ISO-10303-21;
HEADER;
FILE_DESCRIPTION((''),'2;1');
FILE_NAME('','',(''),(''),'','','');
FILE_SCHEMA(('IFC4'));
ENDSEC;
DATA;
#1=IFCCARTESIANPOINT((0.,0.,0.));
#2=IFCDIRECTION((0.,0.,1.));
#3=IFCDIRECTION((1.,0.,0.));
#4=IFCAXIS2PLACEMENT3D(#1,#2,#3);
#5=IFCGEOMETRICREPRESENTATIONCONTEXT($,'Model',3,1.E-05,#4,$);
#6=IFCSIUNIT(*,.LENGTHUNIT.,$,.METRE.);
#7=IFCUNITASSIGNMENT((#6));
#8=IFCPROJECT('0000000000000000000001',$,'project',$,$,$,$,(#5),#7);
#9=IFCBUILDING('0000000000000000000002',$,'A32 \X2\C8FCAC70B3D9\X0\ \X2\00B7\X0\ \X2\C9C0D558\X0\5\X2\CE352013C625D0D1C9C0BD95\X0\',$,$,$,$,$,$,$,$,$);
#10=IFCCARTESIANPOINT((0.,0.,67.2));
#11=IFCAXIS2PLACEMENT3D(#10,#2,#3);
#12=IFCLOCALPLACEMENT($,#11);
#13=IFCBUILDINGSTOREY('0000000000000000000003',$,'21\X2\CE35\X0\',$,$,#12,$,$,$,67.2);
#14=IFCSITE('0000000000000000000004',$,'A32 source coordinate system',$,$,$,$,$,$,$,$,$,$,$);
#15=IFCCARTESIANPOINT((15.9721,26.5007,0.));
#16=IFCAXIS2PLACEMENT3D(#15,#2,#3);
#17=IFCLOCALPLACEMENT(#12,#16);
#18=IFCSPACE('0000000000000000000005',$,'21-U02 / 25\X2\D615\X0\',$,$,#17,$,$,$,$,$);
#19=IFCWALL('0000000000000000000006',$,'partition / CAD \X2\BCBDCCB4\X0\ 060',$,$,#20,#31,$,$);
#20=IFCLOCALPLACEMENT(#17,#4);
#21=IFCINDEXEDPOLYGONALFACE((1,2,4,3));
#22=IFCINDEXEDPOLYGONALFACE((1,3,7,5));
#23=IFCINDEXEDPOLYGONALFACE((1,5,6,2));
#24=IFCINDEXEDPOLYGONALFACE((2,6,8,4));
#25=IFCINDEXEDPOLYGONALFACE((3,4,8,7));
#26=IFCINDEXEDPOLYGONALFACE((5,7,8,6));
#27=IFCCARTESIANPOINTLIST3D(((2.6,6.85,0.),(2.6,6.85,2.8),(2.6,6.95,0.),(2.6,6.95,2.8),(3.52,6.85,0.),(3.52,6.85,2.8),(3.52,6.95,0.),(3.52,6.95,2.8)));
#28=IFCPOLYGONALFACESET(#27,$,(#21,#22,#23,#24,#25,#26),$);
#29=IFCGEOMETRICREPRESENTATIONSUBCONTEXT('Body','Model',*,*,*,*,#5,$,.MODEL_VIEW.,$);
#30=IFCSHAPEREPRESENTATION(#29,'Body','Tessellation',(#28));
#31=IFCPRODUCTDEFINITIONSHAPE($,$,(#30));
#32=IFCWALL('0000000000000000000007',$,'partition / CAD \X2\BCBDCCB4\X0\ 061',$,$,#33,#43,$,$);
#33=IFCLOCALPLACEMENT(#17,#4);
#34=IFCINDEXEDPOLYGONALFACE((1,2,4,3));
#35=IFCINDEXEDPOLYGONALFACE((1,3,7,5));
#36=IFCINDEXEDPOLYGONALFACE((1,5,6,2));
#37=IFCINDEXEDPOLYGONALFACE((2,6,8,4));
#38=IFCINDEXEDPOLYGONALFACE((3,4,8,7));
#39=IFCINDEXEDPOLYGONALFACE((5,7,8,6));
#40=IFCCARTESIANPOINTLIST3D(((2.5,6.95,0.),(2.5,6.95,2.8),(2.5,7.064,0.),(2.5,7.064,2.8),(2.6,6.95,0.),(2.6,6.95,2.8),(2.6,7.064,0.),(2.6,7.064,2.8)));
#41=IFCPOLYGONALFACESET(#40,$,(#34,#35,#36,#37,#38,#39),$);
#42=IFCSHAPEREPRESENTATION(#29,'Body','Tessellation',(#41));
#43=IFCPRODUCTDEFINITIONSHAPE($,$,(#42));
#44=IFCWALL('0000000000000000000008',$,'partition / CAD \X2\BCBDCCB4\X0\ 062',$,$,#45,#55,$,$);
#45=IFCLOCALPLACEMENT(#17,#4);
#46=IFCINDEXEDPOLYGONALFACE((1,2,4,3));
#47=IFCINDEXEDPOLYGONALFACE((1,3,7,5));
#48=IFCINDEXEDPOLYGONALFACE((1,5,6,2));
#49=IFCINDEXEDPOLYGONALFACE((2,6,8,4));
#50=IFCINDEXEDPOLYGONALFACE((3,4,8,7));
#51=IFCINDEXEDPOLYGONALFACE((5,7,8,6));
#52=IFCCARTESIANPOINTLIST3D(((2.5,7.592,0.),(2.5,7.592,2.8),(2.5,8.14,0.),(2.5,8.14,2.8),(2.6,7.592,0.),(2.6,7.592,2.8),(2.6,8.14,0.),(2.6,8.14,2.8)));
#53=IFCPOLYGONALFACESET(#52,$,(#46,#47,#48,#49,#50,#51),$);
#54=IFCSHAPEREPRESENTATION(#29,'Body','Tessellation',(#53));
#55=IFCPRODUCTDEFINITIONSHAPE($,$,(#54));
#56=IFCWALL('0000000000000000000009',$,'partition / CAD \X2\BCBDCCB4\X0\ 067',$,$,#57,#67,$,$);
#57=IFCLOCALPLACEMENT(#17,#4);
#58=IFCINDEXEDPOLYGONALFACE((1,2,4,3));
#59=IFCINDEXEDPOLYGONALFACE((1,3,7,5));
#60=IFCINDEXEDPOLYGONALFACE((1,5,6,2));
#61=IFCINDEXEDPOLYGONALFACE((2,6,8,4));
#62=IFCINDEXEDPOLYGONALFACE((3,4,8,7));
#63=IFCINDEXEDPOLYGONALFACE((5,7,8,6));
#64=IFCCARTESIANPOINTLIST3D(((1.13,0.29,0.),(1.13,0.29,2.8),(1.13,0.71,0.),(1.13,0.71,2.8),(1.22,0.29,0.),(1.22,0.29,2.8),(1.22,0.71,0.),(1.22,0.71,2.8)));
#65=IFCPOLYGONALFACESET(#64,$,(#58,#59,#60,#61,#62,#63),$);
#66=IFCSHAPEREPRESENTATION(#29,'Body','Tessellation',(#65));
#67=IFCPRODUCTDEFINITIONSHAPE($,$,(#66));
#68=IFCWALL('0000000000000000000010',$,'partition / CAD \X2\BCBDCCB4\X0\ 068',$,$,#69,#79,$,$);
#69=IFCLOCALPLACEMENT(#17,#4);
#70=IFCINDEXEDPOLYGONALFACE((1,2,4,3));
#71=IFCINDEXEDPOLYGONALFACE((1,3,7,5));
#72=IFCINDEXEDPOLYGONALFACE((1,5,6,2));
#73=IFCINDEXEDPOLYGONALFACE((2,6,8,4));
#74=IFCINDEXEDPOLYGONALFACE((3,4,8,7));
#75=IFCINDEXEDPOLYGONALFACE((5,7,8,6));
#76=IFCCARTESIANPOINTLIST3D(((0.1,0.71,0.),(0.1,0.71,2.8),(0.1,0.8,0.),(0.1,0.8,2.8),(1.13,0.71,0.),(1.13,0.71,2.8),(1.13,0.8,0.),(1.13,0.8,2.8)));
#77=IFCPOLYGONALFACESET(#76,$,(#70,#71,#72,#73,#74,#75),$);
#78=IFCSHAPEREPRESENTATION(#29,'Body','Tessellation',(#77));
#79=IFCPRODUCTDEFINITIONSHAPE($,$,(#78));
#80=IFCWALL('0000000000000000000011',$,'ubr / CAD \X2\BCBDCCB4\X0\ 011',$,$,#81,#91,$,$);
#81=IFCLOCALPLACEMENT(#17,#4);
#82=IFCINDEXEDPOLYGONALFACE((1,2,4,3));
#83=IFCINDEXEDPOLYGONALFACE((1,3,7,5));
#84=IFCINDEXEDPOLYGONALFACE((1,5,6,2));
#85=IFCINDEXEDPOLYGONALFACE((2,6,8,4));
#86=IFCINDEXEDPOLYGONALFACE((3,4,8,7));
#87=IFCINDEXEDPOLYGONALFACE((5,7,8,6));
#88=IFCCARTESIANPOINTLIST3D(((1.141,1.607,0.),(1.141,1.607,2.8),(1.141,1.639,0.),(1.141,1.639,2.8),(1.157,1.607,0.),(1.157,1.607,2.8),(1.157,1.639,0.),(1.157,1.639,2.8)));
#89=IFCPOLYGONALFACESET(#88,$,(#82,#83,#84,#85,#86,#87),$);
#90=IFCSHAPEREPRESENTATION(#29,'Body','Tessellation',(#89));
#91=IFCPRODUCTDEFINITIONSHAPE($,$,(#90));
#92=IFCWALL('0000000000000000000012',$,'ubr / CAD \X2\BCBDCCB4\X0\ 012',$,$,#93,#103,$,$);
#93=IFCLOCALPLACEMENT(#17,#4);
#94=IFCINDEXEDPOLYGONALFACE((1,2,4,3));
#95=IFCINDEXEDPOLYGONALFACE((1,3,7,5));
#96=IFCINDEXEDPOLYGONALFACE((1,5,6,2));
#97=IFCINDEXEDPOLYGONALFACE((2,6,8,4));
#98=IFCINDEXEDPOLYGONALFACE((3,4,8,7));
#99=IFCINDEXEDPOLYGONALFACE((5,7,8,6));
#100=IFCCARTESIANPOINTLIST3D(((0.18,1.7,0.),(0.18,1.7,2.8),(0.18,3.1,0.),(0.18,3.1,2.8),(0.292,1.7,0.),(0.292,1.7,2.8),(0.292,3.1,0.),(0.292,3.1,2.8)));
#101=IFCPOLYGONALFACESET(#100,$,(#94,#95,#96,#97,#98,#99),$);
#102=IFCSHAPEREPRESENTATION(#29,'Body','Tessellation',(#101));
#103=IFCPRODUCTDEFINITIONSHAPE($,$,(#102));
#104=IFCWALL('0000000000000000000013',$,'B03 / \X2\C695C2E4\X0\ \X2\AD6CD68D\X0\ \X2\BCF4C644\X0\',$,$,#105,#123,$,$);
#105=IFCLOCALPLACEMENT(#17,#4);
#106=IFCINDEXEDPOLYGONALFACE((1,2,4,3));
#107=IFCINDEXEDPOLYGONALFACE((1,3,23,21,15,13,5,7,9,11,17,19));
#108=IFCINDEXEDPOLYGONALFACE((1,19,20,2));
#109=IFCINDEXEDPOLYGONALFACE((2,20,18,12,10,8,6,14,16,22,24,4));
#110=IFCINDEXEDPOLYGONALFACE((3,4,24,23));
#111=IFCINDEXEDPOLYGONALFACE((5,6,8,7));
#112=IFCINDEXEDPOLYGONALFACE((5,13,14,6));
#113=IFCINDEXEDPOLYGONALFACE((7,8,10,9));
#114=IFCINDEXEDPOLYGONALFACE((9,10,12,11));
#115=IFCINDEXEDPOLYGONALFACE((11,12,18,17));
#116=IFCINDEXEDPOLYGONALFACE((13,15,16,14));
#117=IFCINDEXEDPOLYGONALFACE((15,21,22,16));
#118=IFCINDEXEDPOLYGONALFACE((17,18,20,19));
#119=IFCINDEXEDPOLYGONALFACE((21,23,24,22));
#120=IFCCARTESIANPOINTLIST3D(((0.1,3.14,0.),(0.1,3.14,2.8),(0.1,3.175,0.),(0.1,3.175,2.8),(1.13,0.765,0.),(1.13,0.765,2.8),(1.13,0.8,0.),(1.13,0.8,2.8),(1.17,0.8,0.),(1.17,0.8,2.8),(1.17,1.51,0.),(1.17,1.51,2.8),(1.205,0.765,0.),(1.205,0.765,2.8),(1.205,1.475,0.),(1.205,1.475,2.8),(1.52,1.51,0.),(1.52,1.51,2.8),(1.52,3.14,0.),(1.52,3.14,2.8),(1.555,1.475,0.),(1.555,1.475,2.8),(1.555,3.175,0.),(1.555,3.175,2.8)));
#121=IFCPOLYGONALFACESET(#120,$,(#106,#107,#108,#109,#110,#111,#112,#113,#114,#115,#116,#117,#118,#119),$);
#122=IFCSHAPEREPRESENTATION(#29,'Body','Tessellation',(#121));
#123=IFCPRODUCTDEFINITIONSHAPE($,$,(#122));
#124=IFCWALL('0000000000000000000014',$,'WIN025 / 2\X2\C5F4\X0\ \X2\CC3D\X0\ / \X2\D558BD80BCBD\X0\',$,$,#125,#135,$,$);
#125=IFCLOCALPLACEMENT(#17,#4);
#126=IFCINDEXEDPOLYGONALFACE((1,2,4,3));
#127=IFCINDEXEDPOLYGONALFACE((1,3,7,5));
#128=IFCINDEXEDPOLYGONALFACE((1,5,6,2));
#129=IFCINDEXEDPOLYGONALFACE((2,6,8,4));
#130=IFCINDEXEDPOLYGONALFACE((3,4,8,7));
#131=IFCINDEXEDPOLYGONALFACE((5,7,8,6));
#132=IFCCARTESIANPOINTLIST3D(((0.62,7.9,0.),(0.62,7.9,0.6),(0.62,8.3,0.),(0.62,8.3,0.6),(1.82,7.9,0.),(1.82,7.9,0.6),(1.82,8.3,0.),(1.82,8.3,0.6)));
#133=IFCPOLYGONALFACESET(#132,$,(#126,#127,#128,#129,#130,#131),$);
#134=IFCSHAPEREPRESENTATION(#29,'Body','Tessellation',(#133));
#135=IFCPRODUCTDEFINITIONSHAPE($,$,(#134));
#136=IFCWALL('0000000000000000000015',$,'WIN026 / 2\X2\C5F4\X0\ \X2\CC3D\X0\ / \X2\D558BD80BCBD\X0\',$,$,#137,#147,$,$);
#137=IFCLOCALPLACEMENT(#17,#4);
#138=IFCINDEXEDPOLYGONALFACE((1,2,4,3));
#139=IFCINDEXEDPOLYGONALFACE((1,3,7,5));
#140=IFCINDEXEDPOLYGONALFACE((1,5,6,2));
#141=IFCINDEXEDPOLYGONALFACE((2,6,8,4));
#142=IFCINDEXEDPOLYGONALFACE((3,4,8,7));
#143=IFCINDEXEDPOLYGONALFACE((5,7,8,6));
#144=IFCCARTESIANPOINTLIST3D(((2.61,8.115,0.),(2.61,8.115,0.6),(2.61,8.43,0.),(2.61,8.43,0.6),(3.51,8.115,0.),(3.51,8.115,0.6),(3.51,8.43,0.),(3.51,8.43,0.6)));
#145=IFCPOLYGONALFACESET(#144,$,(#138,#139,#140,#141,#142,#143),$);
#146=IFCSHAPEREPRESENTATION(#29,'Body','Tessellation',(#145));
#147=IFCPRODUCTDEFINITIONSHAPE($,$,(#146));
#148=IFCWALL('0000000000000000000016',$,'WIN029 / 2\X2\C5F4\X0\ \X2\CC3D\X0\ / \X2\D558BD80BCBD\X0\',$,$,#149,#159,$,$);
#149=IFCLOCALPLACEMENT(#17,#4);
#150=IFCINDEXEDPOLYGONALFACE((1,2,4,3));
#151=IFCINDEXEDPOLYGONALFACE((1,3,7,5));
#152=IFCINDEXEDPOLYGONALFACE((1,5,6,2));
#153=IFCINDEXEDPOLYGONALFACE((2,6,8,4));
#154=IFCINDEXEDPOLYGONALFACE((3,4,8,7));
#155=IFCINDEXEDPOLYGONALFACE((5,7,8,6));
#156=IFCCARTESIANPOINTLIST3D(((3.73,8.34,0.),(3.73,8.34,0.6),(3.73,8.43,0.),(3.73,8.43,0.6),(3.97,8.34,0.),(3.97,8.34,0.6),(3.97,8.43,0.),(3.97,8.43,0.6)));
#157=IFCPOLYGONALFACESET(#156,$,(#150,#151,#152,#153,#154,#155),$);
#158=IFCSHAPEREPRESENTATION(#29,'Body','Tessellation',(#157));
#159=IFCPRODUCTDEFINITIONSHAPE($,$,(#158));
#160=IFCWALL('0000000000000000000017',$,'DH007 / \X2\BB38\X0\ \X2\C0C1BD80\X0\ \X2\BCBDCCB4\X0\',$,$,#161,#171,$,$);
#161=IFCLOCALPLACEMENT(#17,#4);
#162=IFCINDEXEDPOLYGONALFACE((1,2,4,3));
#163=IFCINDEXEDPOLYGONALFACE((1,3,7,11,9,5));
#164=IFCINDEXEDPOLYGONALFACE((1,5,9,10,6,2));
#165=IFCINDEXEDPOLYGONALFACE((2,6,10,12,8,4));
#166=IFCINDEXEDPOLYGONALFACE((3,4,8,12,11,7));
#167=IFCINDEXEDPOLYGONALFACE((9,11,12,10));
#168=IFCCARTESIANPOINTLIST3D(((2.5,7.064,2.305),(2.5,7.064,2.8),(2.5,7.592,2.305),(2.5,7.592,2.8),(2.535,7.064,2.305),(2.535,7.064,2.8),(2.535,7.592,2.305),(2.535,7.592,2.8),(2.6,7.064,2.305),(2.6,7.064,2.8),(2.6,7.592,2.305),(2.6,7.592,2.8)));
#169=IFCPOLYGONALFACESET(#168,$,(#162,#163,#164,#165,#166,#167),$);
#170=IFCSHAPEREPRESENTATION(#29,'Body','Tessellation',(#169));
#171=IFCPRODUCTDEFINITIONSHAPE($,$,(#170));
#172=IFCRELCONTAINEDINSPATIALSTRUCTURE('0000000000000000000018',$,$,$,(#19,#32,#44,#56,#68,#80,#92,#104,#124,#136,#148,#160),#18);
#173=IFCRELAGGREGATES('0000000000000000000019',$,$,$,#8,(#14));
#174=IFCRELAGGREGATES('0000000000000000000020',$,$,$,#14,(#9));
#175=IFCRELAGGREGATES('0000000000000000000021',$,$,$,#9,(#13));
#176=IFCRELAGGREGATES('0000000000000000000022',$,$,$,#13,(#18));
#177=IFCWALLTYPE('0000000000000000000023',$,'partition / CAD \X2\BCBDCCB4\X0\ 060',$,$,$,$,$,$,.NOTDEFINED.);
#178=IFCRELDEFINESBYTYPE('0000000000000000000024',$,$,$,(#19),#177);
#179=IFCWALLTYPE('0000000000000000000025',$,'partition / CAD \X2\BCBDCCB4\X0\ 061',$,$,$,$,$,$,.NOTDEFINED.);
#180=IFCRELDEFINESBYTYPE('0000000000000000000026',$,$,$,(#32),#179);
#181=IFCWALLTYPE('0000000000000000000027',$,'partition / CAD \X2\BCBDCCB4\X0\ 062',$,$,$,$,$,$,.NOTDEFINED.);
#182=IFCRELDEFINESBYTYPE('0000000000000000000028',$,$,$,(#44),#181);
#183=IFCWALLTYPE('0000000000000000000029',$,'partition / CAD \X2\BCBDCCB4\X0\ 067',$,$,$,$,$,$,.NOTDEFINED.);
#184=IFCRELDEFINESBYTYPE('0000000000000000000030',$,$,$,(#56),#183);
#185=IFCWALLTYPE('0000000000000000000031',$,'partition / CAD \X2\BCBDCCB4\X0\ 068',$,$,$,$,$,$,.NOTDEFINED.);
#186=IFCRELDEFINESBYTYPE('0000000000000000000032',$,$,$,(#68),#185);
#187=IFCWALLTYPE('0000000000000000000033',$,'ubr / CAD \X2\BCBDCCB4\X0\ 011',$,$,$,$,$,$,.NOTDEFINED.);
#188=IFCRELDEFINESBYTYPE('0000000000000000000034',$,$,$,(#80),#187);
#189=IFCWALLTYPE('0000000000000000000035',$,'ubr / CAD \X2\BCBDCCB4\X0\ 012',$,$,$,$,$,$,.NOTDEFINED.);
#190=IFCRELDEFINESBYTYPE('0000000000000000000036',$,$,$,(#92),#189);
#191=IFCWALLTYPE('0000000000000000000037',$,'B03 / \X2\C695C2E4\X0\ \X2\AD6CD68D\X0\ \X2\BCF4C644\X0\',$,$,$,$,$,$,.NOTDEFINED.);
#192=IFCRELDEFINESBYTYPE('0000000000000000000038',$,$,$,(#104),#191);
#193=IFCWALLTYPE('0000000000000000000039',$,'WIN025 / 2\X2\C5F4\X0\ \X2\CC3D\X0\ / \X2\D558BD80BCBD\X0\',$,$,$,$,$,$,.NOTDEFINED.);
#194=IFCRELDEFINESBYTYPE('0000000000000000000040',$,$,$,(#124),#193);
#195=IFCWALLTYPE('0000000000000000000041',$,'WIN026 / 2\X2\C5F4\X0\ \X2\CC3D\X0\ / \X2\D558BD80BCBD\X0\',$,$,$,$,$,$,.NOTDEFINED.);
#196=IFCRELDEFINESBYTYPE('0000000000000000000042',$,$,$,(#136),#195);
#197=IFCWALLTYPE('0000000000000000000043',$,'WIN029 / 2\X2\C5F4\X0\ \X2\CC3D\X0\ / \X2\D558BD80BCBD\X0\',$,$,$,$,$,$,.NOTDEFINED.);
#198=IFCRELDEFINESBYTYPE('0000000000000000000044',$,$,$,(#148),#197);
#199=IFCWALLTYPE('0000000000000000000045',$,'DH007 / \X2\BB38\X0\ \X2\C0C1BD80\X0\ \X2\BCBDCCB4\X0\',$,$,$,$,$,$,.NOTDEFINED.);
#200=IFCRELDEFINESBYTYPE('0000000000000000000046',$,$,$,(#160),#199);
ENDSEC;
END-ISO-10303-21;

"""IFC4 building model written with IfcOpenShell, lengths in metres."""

from ifc_helpers import new_model, si_unit, frame, origin, origin_with_axes, place, context, subcontext, project, spatial, polyline, outline, extrude, source, transform, mapped, type_object, type_shapes, element, save


model = new_model("IFC4")

# Units and contexts
model_context = context("Model", 3, precision=1e-05, world=origin_with_axes())
body_context = subcontext(model_context, "Body", "Model", "MODEL_VIEW")
ifc_project = project(units=[si_unit("LENGTHUNIT", "METRE")], contexts=[model_context])

# Site, building, storey, space
site = spatial("IfcSite", under=ifc_project, Name="A32 source coordinate system")
building = spatial("IfcBuilding", under=site, Name="A32 주거동 · 지하5층–옥탑지붕")
storey_placement = place(None, frame((0.0, 0.0, 67.2), z_axis=(0.0, 0.0, 1.0), x_axis=(1.0, 0.0, 0.0)))
storey = spatial("IfcBuildingStorey", under=building, at=storey_placement, Name="21층", Elevation=67.2)
space_1_placement = place(storey_placement, frame((15.9721, 26.5007, 0.0), z_axis=(0.0, 0.0, 1.0), x_axis=(1.0, 0.0, 0.0)))
space_1 = spatial("IfcSpace", under=storey, at=space_1_placement, Name="21-U02 / 25형")

# Walls
wall_type_1 = type_object("IfcWallType", Name="partition / CAD 벽체 060", PredefinedType="NOTDEFINED")
shared_shape_1 = source(origin(), body_context, "Body", "SweptSolid", [
    extrude(outline(polyline([(3.52, 6.85), (2.6, 6.85), (2.6, 6.95), (3.52, 6.95), (3.52, 6.85)])), origin(), (0.0, 0.0, 1.0), 2.8),
])
type_shapes(wall_type_1, [shared_shape_1])
wall_1_placement = place(space_1_placement, origin_with_axes())
element("IfcWall", 1, at=wall_1_placement, inside=space_1, type_object=wall_type_1, Name="partition / CAD 벽체 060", context=body_context, shape_type="MappedRepresentation", body=[
    mapped(shared_shape_1, transform((0.0, 0.0, 0.0), scale=1.0)),
])
wall_type_2 = type_object("IfcWallType", Name="partition / CAD 벽체 061", PredefinedType="NOTDEFINED")
shared_shape_2 = source(origin(), body_context, "Body", "SweptSolid", [
    extrude(outline(polyline([(2.6, 7.064), (2.6, 6.95), (2.5, 6.95), (2.5, 7.064), (2.6, 7.064)])), origin(), (0.0, 0.0, 1.0), 2.8),
])
type_shapes(wall_type_2, [shared_shape_2])
wall_2_placement = place(space_1_placement, origin_with_axes())
element("IfcWall", 2, at=wall_2_placement, inside=space_1, type_object=wall_type_2, Name="partition / CAD 벽체 061", context=body_context, shape_type="MappedRepresentation", body=[
    mapped(shared_shape_2, transform((0.0, 0.0, 0.0), scale=1.0)),
])
wall_type_3 = type_object("IfcWallType", Name="partition / CAD 벽체 062", PredefinedType="NOTDEFINED")
shared_shape_3 = source(origin(), body_context, "Body", "SweptSolid", [
    extrude(outline(polyline([(2.5, 7.592), (2.5, 8.14), (2.6, 8.14), (2.6, 7.592), (2.5, 7.592)])), origin(), (0.0, 0.0, 1.0), 2.8),
])
type_shapes(wall_type_3, [shared_shape_3])
wall_3_placement = place(space_1_placement, origin_with_axes())
element("IfcWall", 3, at=wall_3_placement, inside=space_1, type_object=wall_type_3, Name="partition / CAD 벽체 062", context=body_context, shape_type="MappedRepresentation", body=[
    mapped(shared_shape_3, transform((0.0, 0.0, 0.0), scale=1.0)),
])
wall_type_4 = type_object("IfcWallType", Name="partition / CAD 벽체 067", PredefinedType="NOTDEFINED")
shared_shape_4 = source(origin(), body_context, "Body", "SweptSolid", [
    extrude(outline(polyline([(1.22, 0.71), (1.22, 0.29), (1.13, 0.29), (1.13, 0.71), (1.22, 0.71)])), origin(), (0.0, 0.0, 1.0), 2.8),
])
type_shapes(wall_type_4, [shared_shape_4])
wall_4_placement = place(space_1_placement, origin_with_axes())
element("IfcWall", 4, at=wall_4_placement, inside=space_1, type_object=wall_type_4, Name="partition / CAD 벽체 067", context=body_context, shape_type="MappedRepresentation", body=[
    mapped(shared_shape_4, transform((0.0, 0.0, 0.0), scale=1.0)),
])
wall_type_5 = type_object("IfcWallType", Name="partition / CAD 벽체 068", PredefinedType="NOTDEFINED")
shared_shape_5 = source(origin(), body_context, "Body", "SweptSolid", [
    extrude(outline(polyline([(1.13, 0.8), (1.13, 0.71), (0.1, 0.71), (0.1, 0.8), (1.13, 0.8)])), origin(), (0.0, 0.0, 1.0), 2.8),
])
type_shapes(wall_type_5, [shared_shape_5])
wall_5_placement = place(space_1_placement, origin_with_axes())
element("IfcWall", 5, at=wall_5_placement, inside=space_1, type_object=wall_type_5, Name="partition / CAD 벽체 068", context=body_context, shape_type="MappedRepresentation", body=[
    mapped(shared_shape_5, transform((0.0, 0.0, 0.0), scale=1.0)),
])
wall_type_6 = type_object("IfcWallType", Name="ubr / CAD 벽체 011", PredefinedType="NOTDEFINED")
shared_shape_6 = source(origin(), body_context, "Body", "SweptSolid", [
    extrude(outline(polyline([(1.141, 1.607), (1.141, 1.639), (1.157, 1.639), (1.157, 1.607), (1.141, 1.607)])), origin(), (0.0, 0.0, 1.0), 2.8),
])
type_shapes(wall_type_6, [shared_shape_6])
wall_6_placement = place(space_1_placement, origin_with_axes())
element("IfcWall", 6, at=wall_6_placement, inside=space_1, type_object=wall_type_6, Name="ubr / CAD 벽체 011", context=body_context, shape_type="MappedRepresentation", body=[
    mapped(shared_shape_6, transform((0.0, 0.0, 0.0), scale=1.0)),
])
wall_type_7 = type_object("IfcWallType", Name="ubr / CAD 벽체 012", PredefinedType="NOTDEFINED")
shared_shape_7 = source(origin(), body_context, "Body", "SweptSolid", [
    extrude(outline(polyline([(0.18, 1.7), (0.18, 3.1), (0.292, 3.1), (0.292, 1.7), (0.18, 1.7)])), origin(), (0.0, 0.0, 1.0), 2.8),
])
type_shapes(wall_type_7, [shared_shape_7])
wall_7_placement = place(space_1_placement, origin_with_axes())
element("IfcWall", 7, at=wall_7_placement, inside=space_1, type_object=wall_type_7, Name="ubr / CAD 벽체 012", context=body_context, shape_type="MappedRepresentation", body=[
    mapped(shared_shape_7, transform((0.0, 0.0, 0.0), scale=1.0)),
])
wall_type_8 = type_object("IfcWallType", Name="B03 / 욕실 구획 보완", PredefinedType="NOTDEFINED")
shared_shape_8 = source(origin(), body_context, "Body", "SweptSolid", [
    extrude(outline(polyline([(1.13, 0.765), (1.13, 0.8), (1.17, 0.8), (1.17, 1.51), (1.52, 1.51), (1.52, 3.14), (0.1, 3.14), (0.1, 3.175), (1.555, 3.175), (1.555, 1.475), (1.205, 1.475), (1.205, 0.765), (1.13, 0.765)])), origin(), (0.0, 0.0, 1.0), 2.8),
])
type_shapes(wall_type_8, [shared_shape_8])
wall_8_placement = place(space_1_placement, origin_with_axes())
element("IfcWall", 8, at=wall_8_placement, inside=space_1, type_object=wall_type_8, Name="B03 / 욕실 구획 보완", context=body_context, shape_type="MappedRepresentation", body=[
    mapped(shared_shape_8, transform((0.0, 0.0, 0.0), scale=1.0)),
])
wall_type_9 = type_object("IfcWallType", Name="WIN025 / 2열 창 / 하부벽", PredefinedType="NOTDEFINED")
shared_shape_9 = source(origin(), body_context, "Body", "SweptSolid", [
    extrude(outline(polyline([(1.82, 8.3), (1.82, 7.9), (0.62, 7.9), (0.62, 8.3), (1.82, 8.3)])), origin(), (0.0, 0.0, 1.0), 0.6),
])
type_shapes(wall_type_9, [shared_shape_9])
wall_9_placement = place(space_1_placement, origin_with_axes())
element("IfcWall", 9, at=wall_9_placement, inside=space_1, type_object=wall_type_9, Name="WIN025 / 2열 창 / 하부벽", context=body_context, shape_type="MappedRepresentation", body=[
    mapped(shared_shape_9, transform((0.0, 0.0, 0.0), scale=1.0)),
])
wall_type_10 = type_object("IfcWallType", Name="WIN026 / 2열 창 / 하부벽", PredefinedType="NOTDEFINED")
shared_shape_10 = source(origin(), body_context, "Body", "SweptSolid", [
    extrude(outline(polyline([(3.51, 8.43), (3.51, 8.115), (2.61, 8.115), (2.61, 8.43), (3.51, 8.43)])), origin(), (0.0, 0.0, 1.0), 0.6),
])
type_shapes(wall_type_10, [shared_shape_10])
wall_10_placement = place(space_1_placement, origin_with_axes())
element("IfcWall", 10, at=wall_10_placement, inside=space_1, type_object=wall_type_10, Name="WIN026 / 2열 창 / 하부벽", context=body_context, shape_type="MappedRepresentation", body=[
    mapped(shared_shape_10, transform((0.0, 0.0, 0.0), scale=1.0)),
])
wall_type_11 = type_object("IfcWallType", Name="WIN029 / 2열 창 / 하부벽", PredefinedType="NOTDEFINED")
shared_shape_11 = source(origin(), body_context, "Body", "SweptSolid", [
    extrude(outline(polyline([(3.97, 8.43), (3.97, 8.34), (3.73, 8.34), (3.73, 8.43), (3.97, 8.43)])), origin(), (0.0, 0.0, 1.0), 0.6),
])
type_shapes(wall_type_11, [shared_shape_11])
wall_11_placement = place(space_1_placement, origin_with_axes())
element("IfcWall", 11, at=wall_11_placement, inside=space_1, type_object=wall_type_11, Name="WIN029 / 2열 창 / 하부벽", context=body_context, shape_type="MappedRepresentation", body=[
    mapped(shared_shape_11, transform((0.0, 0.0, 0.0), scale=1.0)),
])
wall_type_12 = type_object("IfcWallType", Name="DH007 / 문 상부 벽체", PredefinedType="NOTDEFINED")
shared_shape_12 = source(origin(), body_context, "Body", "SweptSolid", [
    extrude(outline(polyline([(2.5, 7.592), (2.535, 7.592), (2.6, 7.592), (2.6, 7.064), (2.535, 7.064), (2.5, 7.064), (2.5, 7.592)])), frame((0.0, 0.0, 2.305)), (0.0, 0.0, 1.0), 0.495),
])
type_shapes(wall_type_12, [shared_shape_12])
wall_12_placement = place(space_1_placement, origin_with_axes())
element("IfcWall", 12, at=wall_12_placement, inside=space_1, type_object=wall_type_12, Name="DH007 / 문 상부 벽체", context=body_context, shape_type="MappedRepresentation", body=[
    mapped(shared_shape_12, transform((0.0, 0.0, 0.0), scale=1.0)),
])

save(model, "model.ifc")
